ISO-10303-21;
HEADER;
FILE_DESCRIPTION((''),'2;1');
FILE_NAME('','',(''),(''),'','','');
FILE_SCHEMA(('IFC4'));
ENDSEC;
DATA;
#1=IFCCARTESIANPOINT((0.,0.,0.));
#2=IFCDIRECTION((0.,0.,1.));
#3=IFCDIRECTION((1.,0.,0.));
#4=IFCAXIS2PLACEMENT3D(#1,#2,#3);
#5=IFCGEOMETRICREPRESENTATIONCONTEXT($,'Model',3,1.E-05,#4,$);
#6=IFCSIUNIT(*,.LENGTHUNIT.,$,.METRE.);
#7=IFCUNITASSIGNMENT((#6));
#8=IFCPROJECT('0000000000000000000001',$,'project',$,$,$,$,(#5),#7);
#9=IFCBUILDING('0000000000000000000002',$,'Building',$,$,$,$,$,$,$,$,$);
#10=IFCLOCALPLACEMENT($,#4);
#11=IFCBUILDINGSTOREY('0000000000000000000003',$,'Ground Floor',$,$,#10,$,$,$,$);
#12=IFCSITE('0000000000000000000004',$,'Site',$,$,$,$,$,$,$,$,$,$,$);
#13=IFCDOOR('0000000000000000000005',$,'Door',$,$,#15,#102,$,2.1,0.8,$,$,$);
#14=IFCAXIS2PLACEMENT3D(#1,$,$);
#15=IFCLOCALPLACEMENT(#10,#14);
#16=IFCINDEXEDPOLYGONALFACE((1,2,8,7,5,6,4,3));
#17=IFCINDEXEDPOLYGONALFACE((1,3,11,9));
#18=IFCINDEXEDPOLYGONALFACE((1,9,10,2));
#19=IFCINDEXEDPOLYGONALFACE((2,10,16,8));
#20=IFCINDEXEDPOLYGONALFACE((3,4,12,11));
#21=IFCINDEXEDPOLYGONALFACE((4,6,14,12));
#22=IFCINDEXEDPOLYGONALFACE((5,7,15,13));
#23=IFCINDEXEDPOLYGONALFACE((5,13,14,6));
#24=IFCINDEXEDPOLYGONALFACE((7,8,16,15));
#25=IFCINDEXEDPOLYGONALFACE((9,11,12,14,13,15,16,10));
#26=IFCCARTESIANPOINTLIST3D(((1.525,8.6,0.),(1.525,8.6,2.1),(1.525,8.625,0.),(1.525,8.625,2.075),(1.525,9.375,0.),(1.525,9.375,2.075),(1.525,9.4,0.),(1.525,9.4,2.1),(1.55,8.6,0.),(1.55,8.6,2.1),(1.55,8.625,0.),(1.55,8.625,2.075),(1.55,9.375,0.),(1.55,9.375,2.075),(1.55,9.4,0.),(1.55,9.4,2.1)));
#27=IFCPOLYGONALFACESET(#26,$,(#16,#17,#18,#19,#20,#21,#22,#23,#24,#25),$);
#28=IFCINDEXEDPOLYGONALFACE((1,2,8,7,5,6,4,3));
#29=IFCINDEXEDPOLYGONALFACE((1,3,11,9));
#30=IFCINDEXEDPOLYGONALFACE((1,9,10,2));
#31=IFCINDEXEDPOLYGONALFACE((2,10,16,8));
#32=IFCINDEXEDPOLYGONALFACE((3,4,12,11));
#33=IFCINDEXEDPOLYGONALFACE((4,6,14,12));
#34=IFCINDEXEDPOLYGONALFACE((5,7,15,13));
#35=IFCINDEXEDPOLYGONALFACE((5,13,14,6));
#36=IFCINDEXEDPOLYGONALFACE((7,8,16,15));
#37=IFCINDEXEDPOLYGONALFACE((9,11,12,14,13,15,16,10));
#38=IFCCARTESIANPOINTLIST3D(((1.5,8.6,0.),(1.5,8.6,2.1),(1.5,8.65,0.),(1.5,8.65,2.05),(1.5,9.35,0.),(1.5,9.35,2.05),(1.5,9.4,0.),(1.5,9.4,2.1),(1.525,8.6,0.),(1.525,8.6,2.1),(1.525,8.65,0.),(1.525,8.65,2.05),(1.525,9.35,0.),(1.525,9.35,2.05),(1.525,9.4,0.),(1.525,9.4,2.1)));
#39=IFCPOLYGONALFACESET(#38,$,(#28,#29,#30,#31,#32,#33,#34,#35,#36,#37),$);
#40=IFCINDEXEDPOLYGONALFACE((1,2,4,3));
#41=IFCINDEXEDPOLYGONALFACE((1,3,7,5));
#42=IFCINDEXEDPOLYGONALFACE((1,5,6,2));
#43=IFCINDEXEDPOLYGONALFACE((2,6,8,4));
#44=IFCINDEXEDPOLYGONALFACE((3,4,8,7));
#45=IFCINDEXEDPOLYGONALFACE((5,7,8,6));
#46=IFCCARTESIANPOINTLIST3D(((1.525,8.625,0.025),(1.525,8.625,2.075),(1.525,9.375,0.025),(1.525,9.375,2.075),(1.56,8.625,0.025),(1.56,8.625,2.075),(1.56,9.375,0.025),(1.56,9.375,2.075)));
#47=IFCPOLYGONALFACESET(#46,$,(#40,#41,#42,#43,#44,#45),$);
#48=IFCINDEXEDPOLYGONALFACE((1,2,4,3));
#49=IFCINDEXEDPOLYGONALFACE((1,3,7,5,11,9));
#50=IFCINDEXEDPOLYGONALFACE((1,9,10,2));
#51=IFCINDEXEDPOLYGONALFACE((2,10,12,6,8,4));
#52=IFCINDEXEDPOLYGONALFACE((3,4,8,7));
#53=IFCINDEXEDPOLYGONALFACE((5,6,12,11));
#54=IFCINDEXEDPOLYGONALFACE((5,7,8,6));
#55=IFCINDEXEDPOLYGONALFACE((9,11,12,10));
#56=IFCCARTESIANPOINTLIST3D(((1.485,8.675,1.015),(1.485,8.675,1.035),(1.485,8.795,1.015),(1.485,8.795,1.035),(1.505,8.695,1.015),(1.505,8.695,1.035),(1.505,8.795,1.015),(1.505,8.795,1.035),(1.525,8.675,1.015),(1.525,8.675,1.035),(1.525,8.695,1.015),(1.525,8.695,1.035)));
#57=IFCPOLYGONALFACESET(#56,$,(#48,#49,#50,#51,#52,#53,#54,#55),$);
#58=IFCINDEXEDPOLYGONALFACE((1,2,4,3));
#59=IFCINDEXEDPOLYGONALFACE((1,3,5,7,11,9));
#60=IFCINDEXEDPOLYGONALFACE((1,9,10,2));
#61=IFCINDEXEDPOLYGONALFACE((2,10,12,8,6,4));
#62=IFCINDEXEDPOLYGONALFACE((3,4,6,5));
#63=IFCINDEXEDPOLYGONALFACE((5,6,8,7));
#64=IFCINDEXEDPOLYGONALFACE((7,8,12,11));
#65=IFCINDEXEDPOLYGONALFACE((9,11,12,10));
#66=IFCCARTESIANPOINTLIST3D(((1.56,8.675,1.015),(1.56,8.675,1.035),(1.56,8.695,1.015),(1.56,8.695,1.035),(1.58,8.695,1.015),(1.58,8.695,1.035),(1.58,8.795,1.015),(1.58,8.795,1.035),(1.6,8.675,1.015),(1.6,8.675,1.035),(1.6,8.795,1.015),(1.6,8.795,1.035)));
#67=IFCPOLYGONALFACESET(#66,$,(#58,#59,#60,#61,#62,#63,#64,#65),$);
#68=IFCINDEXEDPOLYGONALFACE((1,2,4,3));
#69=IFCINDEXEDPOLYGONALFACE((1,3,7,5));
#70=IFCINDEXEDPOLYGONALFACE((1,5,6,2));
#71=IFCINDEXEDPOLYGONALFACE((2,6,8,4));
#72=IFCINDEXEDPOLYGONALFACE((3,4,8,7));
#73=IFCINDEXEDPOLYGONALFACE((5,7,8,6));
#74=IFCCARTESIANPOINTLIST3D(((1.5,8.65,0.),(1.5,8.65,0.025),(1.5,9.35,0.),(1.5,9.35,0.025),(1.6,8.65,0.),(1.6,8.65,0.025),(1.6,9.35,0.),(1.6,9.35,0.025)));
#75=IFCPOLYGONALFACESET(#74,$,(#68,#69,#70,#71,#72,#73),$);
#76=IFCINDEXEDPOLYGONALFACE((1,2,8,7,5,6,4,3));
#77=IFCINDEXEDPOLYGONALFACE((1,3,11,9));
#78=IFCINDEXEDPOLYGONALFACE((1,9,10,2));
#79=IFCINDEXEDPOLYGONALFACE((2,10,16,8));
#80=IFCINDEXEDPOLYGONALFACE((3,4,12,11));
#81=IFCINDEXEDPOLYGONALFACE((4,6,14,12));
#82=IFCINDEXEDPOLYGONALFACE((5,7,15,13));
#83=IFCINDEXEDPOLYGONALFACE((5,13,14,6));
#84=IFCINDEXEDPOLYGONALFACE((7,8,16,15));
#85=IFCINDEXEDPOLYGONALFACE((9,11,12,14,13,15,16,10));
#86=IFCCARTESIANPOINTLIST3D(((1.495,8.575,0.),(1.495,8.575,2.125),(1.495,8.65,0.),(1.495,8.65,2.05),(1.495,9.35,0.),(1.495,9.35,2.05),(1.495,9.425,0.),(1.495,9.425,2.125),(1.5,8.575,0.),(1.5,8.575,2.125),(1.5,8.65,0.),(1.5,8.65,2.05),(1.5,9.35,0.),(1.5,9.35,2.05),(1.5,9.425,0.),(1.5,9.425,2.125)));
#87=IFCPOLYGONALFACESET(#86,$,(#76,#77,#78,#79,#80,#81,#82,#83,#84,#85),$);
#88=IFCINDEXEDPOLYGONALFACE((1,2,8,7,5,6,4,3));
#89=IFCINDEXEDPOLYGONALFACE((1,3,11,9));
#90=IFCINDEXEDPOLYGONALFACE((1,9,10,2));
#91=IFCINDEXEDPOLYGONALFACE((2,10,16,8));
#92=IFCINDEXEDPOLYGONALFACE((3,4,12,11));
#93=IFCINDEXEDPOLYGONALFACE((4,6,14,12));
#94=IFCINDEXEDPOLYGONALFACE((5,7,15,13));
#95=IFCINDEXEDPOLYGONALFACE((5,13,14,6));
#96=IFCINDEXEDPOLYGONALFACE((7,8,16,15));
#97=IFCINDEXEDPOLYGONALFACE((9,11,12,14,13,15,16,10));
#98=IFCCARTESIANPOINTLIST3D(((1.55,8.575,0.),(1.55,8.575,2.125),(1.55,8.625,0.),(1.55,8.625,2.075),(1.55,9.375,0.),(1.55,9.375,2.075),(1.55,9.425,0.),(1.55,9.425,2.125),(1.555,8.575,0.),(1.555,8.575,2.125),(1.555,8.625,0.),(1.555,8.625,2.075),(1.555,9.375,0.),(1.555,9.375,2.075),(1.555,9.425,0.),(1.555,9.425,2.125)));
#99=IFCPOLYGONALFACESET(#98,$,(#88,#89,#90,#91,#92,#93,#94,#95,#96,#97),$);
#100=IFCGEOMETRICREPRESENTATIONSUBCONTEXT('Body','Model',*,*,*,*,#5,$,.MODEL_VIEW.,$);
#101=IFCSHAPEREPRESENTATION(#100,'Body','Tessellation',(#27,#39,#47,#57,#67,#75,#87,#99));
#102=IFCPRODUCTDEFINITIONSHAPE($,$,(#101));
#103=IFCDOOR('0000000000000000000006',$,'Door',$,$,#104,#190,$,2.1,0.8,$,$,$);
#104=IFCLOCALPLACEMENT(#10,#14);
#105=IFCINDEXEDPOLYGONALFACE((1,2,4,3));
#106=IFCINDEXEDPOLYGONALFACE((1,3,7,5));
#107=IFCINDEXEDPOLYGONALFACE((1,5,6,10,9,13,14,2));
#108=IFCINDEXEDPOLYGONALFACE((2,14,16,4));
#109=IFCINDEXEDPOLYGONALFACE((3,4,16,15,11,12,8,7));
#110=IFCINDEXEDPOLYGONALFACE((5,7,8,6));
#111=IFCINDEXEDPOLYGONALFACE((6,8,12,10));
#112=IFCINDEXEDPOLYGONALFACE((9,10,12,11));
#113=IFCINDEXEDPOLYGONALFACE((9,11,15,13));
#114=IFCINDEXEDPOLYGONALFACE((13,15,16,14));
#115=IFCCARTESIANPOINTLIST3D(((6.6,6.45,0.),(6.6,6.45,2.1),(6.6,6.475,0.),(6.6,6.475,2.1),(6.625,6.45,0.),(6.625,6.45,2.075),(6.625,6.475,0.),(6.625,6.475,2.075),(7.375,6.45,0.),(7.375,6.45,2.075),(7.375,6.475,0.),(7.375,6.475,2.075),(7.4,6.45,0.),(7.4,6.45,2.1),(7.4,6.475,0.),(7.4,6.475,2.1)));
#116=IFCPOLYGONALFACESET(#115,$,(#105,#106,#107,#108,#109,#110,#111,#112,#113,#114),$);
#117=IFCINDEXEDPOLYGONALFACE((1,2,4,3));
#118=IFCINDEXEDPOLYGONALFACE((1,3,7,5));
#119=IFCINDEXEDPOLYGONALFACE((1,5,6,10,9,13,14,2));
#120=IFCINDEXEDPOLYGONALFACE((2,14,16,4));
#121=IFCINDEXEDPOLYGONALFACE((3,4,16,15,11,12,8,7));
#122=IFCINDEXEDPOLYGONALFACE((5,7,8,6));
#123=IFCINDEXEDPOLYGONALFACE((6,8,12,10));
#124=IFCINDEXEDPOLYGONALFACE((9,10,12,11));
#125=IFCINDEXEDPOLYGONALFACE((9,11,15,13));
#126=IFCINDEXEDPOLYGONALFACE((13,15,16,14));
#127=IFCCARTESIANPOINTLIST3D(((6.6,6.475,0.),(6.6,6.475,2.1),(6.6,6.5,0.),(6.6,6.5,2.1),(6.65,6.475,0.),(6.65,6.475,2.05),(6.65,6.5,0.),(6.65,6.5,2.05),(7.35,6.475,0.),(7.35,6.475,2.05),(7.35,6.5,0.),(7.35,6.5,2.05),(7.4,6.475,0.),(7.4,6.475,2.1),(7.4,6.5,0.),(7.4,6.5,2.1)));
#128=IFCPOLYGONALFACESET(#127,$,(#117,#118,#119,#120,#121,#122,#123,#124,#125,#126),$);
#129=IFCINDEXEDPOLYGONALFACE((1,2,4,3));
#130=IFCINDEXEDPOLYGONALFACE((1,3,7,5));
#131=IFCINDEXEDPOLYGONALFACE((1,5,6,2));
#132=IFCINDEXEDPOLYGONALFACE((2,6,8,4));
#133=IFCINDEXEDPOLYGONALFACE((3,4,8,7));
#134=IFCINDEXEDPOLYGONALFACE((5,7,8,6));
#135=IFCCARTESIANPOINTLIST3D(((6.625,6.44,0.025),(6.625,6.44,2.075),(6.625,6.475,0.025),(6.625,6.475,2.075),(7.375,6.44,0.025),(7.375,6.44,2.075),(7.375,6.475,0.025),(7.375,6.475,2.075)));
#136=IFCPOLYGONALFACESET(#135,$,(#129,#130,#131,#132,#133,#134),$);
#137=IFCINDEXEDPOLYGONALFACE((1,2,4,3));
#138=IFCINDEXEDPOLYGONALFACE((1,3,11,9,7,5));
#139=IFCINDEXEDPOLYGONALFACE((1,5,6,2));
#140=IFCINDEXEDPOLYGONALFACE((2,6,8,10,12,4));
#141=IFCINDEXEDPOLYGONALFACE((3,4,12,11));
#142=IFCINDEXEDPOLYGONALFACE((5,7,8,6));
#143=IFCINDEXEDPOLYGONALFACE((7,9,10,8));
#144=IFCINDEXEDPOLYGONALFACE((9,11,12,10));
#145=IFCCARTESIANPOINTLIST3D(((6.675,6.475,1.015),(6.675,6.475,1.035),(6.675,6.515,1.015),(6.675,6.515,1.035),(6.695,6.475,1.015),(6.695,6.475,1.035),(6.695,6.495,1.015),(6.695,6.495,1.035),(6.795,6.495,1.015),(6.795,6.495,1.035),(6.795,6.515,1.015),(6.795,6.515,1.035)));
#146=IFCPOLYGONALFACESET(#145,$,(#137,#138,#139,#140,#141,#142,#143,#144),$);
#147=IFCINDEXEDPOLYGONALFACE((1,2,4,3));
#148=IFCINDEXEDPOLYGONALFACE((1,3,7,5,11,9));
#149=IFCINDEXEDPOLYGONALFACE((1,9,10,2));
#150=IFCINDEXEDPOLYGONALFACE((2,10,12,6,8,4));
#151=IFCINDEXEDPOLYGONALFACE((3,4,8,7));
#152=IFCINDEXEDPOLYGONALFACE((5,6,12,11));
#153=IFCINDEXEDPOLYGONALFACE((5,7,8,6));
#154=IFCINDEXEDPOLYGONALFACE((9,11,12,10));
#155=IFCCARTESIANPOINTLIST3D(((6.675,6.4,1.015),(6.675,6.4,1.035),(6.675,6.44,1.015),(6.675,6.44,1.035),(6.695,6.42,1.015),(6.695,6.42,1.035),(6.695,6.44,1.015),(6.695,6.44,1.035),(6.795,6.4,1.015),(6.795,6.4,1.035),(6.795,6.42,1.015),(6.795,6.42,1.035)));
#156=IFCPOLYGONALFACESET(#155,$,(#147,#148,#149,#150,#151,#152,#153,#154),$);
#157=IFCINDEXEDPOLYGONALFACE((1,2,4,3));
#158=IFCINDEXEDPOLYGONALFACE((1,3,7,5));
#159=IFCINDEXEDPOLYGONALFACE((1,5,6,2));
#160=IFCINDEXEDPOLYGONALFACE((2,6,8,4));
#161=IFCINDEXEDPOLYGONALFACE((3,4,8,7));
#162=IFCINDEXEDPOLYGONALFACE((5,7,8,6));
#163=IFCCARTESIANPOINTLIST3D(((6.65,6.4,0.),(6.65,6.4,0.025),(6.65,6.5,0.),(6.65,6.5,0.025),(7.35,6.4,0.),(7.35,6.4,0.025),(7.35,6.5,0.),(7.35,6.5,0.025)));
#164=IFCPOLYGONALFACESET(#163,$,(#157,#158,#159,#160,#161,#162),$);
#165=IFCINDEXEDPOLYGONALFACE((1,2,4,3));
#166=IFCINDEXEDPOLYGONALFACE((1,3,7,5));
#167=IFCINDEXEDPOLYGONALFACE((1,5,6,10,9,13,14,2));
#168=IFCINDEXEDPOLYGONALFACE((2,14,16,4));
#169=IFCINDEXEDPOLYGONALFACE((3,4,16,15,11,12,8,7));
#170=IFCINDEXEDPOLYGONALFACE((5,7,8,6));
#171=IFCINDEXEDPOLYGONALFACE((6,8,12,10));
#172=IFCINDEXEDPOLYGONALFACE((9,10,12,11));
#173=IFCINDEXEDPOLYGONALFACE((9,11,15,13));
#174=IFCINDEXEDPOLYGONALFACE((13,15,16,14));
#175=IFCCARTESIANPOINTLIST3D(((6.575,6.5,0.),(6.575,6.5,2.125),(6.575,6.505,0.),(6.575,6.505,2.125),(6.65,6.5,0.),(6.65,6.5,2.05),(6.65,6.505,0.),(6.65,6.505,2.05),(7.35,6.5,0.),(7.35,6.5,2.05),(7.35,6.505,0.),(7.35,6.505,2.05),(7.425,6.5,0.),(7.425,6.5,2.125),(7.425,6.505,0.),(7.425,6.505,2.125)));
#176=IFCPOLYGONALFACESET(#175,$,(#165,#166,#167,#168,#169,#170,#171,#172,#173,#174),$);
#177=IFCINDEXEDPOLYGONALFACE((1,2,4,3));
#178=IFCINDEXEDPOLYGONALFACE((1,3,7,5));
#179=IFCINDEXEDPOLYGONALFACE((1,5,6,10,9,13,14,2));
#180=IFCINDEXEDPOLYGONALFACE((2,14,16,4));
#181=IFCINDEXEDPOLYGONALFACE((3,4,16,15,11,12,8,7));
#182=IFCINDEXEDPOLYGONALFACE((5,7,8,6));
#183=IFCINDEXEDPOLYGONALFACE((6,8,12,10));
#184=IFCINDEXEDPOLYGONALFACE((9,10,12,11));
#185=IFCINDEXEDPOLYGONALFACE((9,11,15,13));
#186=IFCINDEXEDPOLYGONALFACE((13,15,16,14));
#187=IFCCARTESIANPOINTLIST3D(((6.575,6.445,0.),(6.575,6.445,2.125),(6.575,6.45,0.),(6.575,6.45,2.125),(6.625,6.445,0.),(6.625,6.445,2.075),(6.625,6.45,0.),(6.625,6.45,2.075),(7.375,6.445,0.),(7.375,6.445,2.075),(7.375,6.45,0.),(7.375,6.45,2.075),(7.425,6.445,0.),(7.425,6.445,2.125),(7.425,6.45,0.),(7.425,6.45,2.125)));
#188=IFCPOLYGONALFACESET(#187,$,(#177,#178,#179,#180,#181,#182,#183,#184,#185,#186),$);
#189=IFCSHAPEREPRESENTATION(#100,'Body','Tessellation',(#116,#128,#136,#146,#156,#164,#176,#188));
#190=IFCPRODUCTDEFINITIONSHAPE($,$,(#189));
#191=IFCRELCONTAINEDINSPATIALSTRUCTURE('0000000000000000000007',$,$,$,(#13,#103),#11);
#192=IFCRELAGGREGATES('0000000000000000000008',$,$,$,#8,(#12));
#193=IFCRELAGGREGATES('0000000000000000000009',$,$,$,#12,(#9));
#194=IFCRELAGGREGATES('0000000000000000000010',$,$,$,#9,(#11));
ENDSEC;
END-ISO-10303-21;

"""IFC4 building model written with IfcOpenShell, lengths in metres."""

from ifc_helpers import new_model, si_unit, frame, origin_with_axes, place, context, subcontext, project, spatial, line, indexed_curve, outline, extrude, element, save


model = new_model("IFC4")

# Units and contexts
model_context = context("Model", 3, precision=1e-05, world=origin_with_axes())
body_context = subcontext(model_context, "Body", "Model", "MODEL_VIEW")
ifc_project = project(units=[si_unit("LENGTHUNIT", "METRE")], contexts=[model_context])

# Site, building, storey
site = spatial("IfcSite", under=ifc_project, Name="Site")
building = spatial("IfcBuilding", under=site, Name="Building")
storey_placement = place(None, origin_with_axes())
storey = spatial("IfcBuildingStorey", under=building, at=storey_placement, Name="Ground Floor")

# Doors
door_1_placement = place(storey_placement, frame((1.5, 9.4, 0.0), z_axis=(0.0, 0.0, 1.0), x_axis=(0.0, -1.0, 0.0)))
element("IfcDoor", 1, at=door_1_placement, inside=storey, Name="Door", OverallHeight=2.1, OverallWidth=0.8, context=body_context, shape_type="SweptSolid", body=[
    extrude(outline(indexed_curve([(0.0, 0.0), (0.0, 2.1), (0.8, 2.1), (0.8, 0.0), (0.775, 0.0), (0.775, 2.075), (0.025, 2.075), (0.025, 0.0)], segments=[line(1, 2, 3, 4, 5, 6, 7, 8, 1)])), frame((0.0, 0.025, 0.0), z_axis=(0.0, -1.0, 0.0), x_axis=(1.0, 0.0, 0.0)), (0.0, 0.0, -1.0), 0.025),
    extrude(outline(indexed_curve([(0.0, 0.0), (0.0, 2.1), (0.8, 2.1), (0.8, 0.0), (0.75, 0.0), (0.75, 2.05), (0.05, 2.05), (0.05, 0.0)], segments=[line(1, 2, 3, 4, 5, 6, 7, 8, 1)])), frame((0.0, 0.0, 0.0), z_axis=(0.0, -1.0, 0.0), x_axis=(1.0, 0.0, 0.0)), (0.0, 0.0, -1.0), 0.025),
    extrude(outline(indexed_curve([(0.0, 0.0), (0.75, 0.0), (0.75, 0.035), (0.0, 0.035)], segments=[line(1, 2, 3, 4, 1)])), frame((0.025, 0.025, 0.025), z_axis=(0.0, 0.0, 1.0), x_axis=(1.0, 0.0, 0.0)), (0.0, 0.0, 1.0), 2.05),
    extrude(outline(indexed_curve([(0.0, 0.0), (0.0, -0.04), (-0.12, -0.04), (-0.12, -0.02), (-0.02, -0.02), (-0.02, 0.0)], segments=[line(1, 2, 3, 4, 5, 6, 1)])), frame((0.725, 0.025, 1.015), z_axis=(0.0, 0.0, 1.0), x_axis=(1.0, 0.0, 0.0)), (0.0, 0.0, 1.0), 0.02),
    extrude(outline(indexed_curve([(0.0, 0.0), (0.0, 0.04), (-0.12, 0.04), (-0.12, 0.02), (-0.02, 0.02), (-0.02, 0.0)], segments=[line(1, 2, 3, 4, 5, 6, 1)])), frame((0.725, 0.06, 1.015), z_axis=(0.0, 0.0, 1.0), x_axis=(1.0, 0.0, 0.0)), (0.0, 0.0, 1.0), 0.02),
    extrude(outline(indexed_curve([(0.0, 0.0), (0.7, 0.0), (0.7, 0.1), (0.0, 0.1)], segments=[line(1, 2, 3, 4, 1)])), frame((0.05, 0.0, 0.0), z_axis=(0.0, 0.0, 1.0), x_axis=(1.0, 0.0, 0.0)), (0.0, 0.0, 1.0), 0.025),
    extrude(outline(indexed_curve([(0.0, 0.0), (0.0, 2.125), (0.85, 2.125), (0.85, 0.0), (0.775, 0.0), (0.775, 2.05), (0.075, 2.05), (0.075, 0.0)], segments=[line(1, 2, 3, 4, 5, 6, 7, 8, 1)])), frame((-0.025, -0.005, 0.0), z_axis=(0.0, -1.0, 0.0), x_axis=(1.0, 0.0, 0.0)), (0.0, 0.0, -1.0), 0.005),
    extrude(outline(indexed_curve([(0.0, 0.0), (0.0, 2.125), (0.85, 2.125), (0.85, 0.0), (0.8, 0.0), (0.8, 2.075), (0.05, 2.075), (0.05, 0.0)], segments=[line(1, 2, 3, 4, 5, 6, 7, 8, 1)])), frame((-0.025, 0.05, 0.0), z_axis=(0.0, -1.0, 0.0), x_axis=(1.0, 0.0, 0.0)), (0.0, 0.0, -1.0), 0.005),
])
door_2_placement = place(storey_placement, frame((7.4, 6.5, 0.0), z_axis=(0.0, 0.0, 1.0), x_axis=(-1.0, 0.0, 0.0)))
element("IfcDoor", 2, at=door_2_placement, inside=storey, Name="Door", OverallHeight=2.1, OverallWidth=0.8, context=body_context, shape_type="SweptSolid", body=[
    extrude(outline(indexed_curve([(0.0, 0.0), (0.0, 2.1), (0.8, 2.1), (0.8, 0.0), (0.775, 0.0), (0.775, 2.075), (0.025, 2.075), (0.025, 0.0)], segments=[line(1, 2, 3, 4, 5, 6, 7, 8, 1)])), frame((0.0, 0.025, 0.0), z_axis=(0.0, -1.0, 0.0), x_axis=(1.0, 0.0, 0.0)), (0.0, 0.0, -1.0), 0.025),
    extrude(outline(indexed_curve([(0.0, 0.0), (0.0, 2.1), (0.8, 2.1), (0.8, 0.0), (0.75, 0.0), (0.75, 2.05), (0.05, 2.05), (0.05, 0.0)], segments=[line(1, 2, 3, 4, 5, 6, 7, 8, 1)])), frame((0.0, 0.0, 0.0), z_axis=(0.0, -1.0, 0.0), x_axis=(1.0, 0.0, 0.0)), (0.0, 0.0, -1.0), 0.025),
    extrude(outline(indexed_curve([(0.0, 0.0), (0.75, 0.0), (0.75, 0.035), (0.0, 0.035)], segments=[line(1, 2, 3, 4, 1)])), frame((0.025, 0.025, 0.025), z_axis=(0.0, 0.0, 1.0), x_axis=(1.0, 0.0, 0.0)), (0.0, 0.0, 1.0), 2.05),
    extrude(outline(indexed_curve([(0.0, 0.0), (0.0, -0.04), (-0.12, -0.04), (-0.12, -0.02), (-0.02, -0.02), (-0.02, 0.0)], segments=[line(1, 2, 3, 4, 5, 6, 1)])), frame((0.725, 0.025, 1.015), z_axis=(0.0, 0.0, 1.0), x_axis=(1.0, 0.0, 0.0)), (0.0, 0.0, 1.0), 0.02),
    extrude(outline(indexed_curve([(0.0, 0.0), (0.0, 0.04), (-0.12, 0.04), (-0.12, 0.02), (-0.02, 0.02), (-0.02, 0.0)], segments=[line(1, 2, 3, 4, 5, 6, 1)])), frame((0.725, 0.06, 1.015), z_axis=(0.0, 0.0, 1.0), x_axis=(1.0, 0.0, 0.0)), (0.0, 0.0, 1.0), 0.02),
    extrude(outline(indexed_curve([(0.0, 0.0), (0.7, 0.0), (0.7, 0.1), (0.0, 0.1)], segments=[line(1, 2, 3, 4, 1)])), frame((0.05, 0.0, 0.0), z_axis=(0.0, 0.0, 1.0), x_axis=(1.0, 0.0, 0.0)), (0.0, 0.0, 1.0), 0.025),
    extrude(outline(indexed_curve([(0.0, 0.0), (0.0, 2.125), (0.85, 2.125), (0.85, 0.0), (0.775, 0.0), (0.775, 2.05), (0.075, 2.05), (0.075, 0.0)], segments=[line(1, 2, 3, 4, 5, 6, 7, 8, 1)])), frame((-0.025, -0.005, 0.0), z_axis=(0.0, -1.0, 0.0), x_axis=(1.0, 0.0, 0.0)), (0.0, 0.0, -1.0), 0.005),
    extrude(outline(indexed_curve([(0.0, 0.0), (0.0, 2.125), (0.85, 2.125), (0.85, 0.0), (0.8, 0.0), (0.8, 2.075), (0.05, 2.075), (0.05, 0.0)], segments=[line(1, 2, 3, 4, 5, 6, 7, 8, 1)])), frame((-0.025, 0.05, 0.0), z_axis=(0.0, -1.0, 0.0), x_axis=(1.0, 0.0, 0.0)), (0.0, 0.0, -1.0), 0.005),
])

save(model, "model.ifc")
